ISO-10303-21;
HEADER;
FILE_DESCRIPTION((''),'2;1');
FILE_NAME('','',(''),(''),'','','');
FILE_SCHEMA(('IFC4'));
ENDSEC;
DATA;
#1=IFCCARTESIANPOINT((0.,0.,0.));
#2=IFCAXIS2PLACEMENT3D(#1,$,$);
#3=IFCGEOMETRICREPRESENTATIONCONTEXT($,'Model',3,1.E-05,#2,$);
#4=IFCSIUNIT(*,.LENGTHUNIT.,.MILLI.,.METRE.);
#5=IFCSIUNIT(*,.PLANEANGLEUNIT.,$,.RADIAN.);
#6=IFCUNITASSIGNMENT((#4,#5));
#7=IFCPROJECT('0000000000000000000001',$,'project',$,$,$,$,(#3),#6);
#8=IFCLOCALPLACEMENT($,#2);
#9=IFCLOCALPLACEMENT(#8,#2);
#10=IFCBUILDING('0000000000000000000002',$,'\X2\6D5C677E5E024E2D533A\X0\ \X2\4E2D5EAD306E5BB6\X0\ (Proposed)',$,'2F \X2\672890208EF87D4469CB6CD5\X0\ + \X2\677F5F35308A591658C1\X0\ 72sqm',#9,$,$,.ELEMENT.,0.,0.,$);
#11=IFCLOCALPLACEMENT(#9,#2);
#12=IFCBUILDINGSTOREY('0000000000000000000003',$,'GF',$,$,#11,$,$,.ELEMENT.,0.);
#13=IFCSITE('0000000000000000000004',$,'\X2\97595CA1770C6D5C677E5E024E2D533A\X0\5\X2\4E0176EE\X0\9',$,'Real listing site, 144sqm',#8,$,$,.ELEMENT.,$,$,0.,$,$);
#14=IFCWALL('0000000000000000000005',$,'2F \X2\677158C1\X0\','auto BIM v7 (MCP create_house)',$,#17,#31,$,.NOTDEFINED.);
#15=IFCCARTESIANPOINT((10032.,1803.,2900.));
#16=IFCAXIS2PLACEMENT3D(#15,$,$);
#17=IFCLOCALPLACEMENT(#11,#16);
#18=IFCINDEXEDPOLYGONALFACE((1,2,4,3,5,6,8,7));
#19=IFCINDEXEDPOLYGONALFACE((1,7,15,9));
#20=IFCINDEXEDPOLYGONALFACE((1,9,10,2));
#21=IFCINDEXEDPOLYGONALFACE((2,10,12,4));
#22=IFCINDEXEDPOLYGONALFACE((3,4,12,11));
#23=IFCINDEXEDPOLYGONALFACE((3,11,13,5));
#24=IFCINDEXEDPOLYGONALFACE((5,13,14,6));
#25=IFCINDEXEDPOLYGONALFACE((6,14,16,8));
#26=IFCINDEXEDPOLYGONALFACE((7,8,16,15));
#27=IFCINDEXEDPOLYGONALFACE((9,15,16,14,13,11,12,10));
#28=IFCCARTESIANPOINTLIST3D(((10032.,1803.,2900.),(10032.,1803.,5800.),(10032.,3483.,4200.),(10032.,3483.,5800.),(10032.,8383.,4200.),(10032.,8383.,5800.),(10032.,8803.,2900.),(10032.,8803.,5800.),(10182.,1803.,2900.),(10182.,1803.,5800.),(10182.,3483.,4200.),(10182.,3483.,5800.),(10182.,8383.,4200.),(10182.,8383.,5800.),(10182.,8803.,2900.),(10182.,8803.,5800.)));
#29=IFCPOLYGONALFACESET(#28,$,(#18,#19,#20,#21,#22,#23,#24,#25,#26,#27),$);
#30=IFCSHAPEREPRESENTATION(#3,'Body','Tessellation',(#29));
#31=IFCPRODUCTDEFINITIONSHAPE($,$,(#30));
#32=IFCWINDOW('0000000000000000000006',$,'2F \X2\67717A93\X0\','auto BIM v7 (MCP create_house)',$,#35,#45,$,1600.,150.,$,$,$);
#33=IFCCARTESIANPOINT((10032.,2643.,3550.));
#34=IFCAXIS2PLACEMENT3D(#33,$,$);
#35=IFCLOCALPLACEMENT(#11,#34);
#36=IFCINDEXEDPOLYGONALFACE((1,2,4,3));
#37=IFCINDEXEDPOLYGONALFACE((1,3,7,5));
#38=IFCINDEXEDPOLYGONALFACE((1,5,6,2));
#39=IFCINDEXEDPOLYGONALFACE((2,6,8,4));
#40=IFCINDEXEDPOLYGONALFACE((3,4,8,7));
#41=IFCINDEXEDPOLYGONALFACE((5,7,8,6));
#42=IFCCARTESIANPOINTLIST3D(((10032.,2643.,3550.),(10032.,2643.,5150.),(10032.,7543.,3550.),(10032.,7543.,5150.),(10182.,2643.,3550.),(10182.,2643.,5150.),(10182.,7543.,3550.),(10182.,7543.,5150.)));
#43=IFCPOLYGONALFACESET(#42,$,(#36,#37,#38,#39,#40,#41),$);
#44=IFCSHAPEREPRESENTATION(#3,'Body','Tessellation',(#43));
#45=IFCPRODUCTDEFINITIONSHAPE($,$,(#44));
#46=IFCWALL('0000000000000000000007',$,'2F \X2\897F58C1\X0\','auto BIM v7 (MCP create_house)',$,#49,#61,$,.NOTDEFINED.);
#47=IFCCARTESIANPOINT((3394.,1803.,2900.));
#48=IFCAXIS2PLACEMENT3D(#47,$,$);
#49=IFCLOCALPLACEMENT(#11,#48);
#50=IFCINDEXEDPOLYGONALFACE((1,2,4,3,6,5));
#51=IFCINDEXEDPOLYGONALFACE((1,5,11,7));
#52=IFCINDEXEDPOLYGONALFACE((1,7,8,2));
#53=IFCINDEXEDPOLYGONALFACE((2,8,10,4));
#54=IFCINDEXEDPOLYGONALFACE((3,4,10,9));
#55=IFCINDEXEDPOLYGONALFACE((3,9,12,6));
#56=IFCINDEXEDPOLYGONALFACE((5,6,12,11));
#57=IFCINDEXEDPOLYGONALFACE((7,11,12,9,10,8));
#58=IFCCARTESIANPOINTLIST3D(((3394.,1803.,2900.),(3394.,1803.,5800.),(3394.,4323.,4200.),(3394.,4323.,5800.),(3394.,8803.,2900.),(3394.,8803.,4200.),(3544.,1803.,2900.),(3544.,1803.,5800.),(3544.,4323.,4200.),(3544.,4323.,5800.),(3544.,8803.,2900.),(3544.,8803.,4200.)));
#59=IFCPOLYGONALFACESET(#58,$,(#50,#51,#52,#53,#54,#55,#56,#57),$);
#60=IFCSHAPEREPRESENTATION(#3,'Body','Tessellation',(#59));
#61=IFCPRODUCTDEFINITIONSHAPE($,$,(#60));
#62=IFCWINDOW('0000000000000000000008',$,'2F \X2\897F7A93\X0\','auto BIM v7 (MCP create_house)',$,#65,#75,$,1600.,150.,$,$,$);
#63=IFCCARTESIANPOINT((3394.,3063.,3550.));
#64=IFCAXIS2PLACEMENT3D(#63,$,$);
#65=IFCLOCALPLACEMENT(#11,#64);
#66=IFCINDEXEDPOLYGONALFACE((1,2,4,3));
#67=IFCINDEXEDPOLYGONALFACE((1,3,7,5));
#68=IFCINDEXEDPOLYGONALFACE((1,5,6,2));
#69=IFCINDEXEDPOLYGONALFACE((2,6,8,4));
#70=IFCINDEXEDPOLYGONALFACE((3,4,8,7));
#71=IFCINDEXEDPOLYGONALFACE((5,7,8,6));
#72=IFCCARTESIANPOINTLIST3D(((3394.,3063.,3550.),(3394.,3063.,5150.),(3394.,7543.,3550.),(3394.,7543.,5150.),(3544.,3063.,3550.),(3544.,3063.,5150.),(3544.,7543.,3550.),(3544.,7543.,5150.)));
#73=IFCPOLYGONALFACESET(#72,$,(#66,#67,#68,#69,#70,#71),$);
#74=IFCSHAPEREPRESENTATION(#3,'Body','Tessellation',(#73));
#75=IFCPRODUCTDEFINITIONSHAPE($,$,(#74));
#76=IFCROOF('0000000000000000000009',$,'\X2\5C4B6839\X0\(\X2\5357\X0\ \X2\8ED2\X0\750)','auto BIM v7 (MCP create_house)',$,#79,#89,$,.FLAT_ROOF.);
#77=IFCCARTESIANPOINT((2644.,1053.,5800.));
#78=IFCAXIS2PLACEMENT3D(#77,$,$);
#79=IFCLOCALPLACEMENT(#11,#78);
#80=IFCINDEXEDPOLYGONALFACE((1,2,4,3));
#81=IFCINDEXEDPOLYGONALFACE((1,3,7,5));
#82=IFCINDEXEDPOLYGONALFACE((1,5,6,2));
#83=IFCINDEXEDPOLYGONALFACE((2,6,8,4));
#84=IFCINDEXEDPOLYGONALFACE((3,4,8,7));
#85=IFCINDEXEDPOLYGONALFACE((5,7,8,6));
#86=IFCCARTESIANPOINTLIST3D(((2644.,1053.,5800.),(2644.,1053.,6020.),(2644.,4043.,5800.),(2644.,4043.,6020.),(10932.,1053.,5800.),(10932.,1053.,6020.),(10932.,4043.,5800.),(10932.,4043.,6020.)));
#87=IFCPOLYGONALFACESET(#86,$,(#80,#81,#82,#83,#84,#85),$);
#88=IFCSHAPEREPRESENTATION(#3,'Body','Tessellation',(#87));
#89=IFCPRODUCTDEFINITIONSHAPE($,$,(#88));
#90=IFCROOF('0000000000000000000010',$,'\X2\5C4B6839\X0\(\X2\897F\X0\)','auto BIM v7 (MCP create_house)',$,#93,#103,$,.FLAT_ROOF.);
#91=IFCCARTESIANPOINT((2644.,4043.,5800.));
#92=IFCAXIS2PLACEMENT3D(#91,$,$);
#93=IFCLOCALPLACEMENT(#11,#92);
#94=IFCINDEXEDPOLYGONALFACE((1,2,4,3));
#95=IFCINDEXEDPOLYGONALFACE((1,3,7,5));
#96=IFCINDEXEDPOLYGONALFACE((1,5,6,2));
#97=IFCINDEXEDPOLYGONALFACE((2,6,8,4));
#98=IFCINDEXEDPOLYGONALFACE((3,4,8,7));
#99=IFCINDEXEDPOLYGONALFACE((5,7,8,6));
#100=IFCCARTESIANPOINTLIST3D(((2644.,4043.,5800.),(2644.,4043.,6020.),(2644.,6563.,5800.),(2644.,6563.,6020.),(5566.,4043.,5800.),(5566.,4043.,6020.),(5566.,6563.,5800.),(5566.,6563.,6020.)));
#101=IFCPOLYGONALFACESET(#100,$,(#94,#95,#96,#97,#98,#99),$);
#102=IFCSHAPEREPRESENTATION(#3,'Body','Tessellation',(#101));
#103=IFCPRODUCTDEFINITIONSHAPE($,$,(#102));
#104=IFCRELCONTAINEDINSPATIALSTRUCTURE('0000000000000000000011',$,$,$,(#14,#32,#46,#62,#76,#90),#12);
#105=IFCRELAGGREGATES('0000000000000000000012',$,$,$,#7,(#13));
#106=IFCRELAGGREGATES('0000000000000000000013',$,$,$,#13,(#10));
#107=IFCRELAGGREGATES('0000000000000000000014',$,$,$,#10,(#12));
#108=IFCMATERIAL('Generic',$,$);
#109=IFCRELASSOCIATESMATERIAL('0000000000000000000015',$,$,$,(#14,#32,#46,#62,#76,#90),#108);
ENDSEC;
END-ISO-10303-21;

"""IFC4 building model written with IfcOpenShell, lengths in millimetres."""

from ifc_helpers import new_model, si_unit, frame, frame_2d, origin, place, context, project, spatial, rectangle, extrude, material, element, fill, save


model = new_model("IFC4")

# Units and contexts
model_context = context("Model", 3, precision=1e-05, world=origin())
ifc_project = project(units=[si_unit("LENGTHUNIT", "METRE", prefix="MILLI"), si_unit("PLANEANGLEUNIT", "RADIAN")], contexts=[model_context])

# Site, building, storey
site_placement = place(None, origin())
site = spatial("IfcSite", under=ifc_project, at=site_placement, Name="静岡県浜松市中区5丁目9", ObjectType="Real listing site, 144sqm", CompositionType="ELEMENT", RefElevation=0.0)
building_placement = place(site_placement, origin())
building = spatial("IfcBuilding", under=site, at=building_placement, Name="浜松市中区 中庭の家 (Proposed)", ObjectType="2F 木造軸組構法 + 板張り外壁 72sqm", CompositionType="ELEMENT", ElevationOfRefHeight=0.0, ElevationOfTerrain=0.0)
storey_placement = place(building_placement, origin())
storey = spatial("IfcBuildingStorey", under=building, at=storey_placement, Name="GF", CompositionType="ELEMENT", Elevation=0.0)

# Shared definitions
ifc_material = material(Name="Generic")

# Walls, openings, windows
wall_1_placement = place(storey_placement, frame((10032.0, 1803.0, 2900.0)))
wall_1 = element("IfcWall", 1, at=wall_1_placement, inside=storey, material=ifc_material, Name="2F 東壁", Description="auto BIM v7 (MCP create_house)", PredefinedType="NOTDEFINED", context=model_context, shape_type="SweptSolid", body=[
    extrude(rectangle(XDim=150.0, YDim=7000.0, at=frame_2d((75.0, 3500.0))), frame((10032.0, 1803.0, 2900.0)), (0.0, 0.0, 1.0), 2900.0),
])
opening_1_placement = place(storey_placement, frame((10032.0, 2643.0, 3550.0)))
opening_1 = element("IfcOpeningElement", 2, at=opening_1_placement, cuts=wall_1, PredefinedType="NOTDEFINED", context=model_context, shape_type="SweptSolid", body=[
    extrude(rectangle(XDim=150.0, YDim=4900.0, at=frame_2d((75.0, 2450.0))), frame((10032.0, 2643.0, 3550.0)), (0.0, 0.0, 1.0), 1600.0),
])
window_1_placement = place(storey_placement, frame((10032.0, 2643.0, 3550.0)))
window_1 = element("IfcWindow", 3, at=window_1_placement, inside=storey, material=ifc_material, Name="2F 東窓", Description="auto BIM v7 (MCP create_house)", OverallHeight=1600.0, OverallWidth=150.0, context=model_context, shape_type="SweptSolid", body=[
    extrude(rectangle(XDim=150.0, YDim=4900.0, at=frame_2d((75.0, 2450.0))), frame((10032.0, 2643.0, 3550.0)), (0.0, 0.0, 1.0), 1600.0),
])
fill(opening_1, window_1)
wall_2_placement = place(storey_placement, frame((3394.0, 1803.0, 2900.0)))
wall_2 = element("IfcWall", 4, at=wall_2_placement, inside=storey, material=ifc_material, Name="2F 西壁", Description="auto BIM v7 (MCP create_house)", PredefinedType="NOTDEFINED", context=model_context, shape_type="SweptSolid", body=[
    extrude(rectangle(XDim=150.0, YDim=7000.0, at=frame_2d((75.0, 3500.0))), frame((3394.0, 1803.0, 2900.0)), (0.0, 0.0, 1.0), 2900.0),
])
opening_2_placement = place(storey_placement, frame((3394.0, 3063.0, 3550.0)))
opening_2 = element("IfcOpeningElement", 5, at=opening_2_placement, cuts=wall_2, PredefinedType="NOTDEFINED", context=model_context, shape_type="SweptSolid", body=[
    extrude(rectangle(XDim=150.0, YDim=4480.0, at=frame_2d((75.0, 2240.0))), frame((3394.0, 3063.0, 3550.0)), (0.0, 0.0, 1.0), 1600.0),
])
window_2_placement = place(storey_placement, frame((3394.0, 3063.0, 3550.0)))
window_2 = element("IfcWindow", 6, at=window_2_placement, inside=storey, material=ifc_material, Name="2F 西窓", Description="auto BIM v7 (MCP create_house)", OverallHeight=1600.0, OverallWidth=150.0, context=model_context, shape_type="SweptSolid", body=[
    extrude(rectangle(XDim=150.0, YDim=4480.0, at=frame_2d((75.0, 2240.0))), frame((3394.0, 3063.0, 3550.0)), (0.0, 0.0, 1.0), 1600.0),
])
fill(opening_2, window_2)

# Roofs
roof_1_placement = place(storey_placement, frame((2644.0, 1053.0, 5800.0)))
element("IfcRoof", 7, at=roof_1_placement, inside=storey, material=ifc_material, Name="屋根(南 軒750)", Description="auto BIM v7 (MCP create_house)", PredefinedType="FLAT_ROOF", context=model_context, shape_type="SweptSolid", body=[
    extrude(rectangle(XDim=8288.0, YDim=2990.0, at=frame_2d((4144.0, 1495.0))), frame((2644.0, 1053.0, 5800.0)), (0.0, 0.0, 1.0), 220.0),
])
roof_2_placement = place(storey_placement, frame((2644.0, 4043.0, 5800.0)))
element("IfcRoof", 8, at=roof_2_placement, inside=storey, material=ifc_material, Name="屋根(西)", Description="auto BIM v7 (MCP create_house)", PredefinedType="FLAT_ROOF", context=model_context, shape_type="SweptSolid", body=[
    extrude(rectangle(XDim=2922.0, YDim=2520.0, at=frame_2d((1461.0, 1260.0))), frame((2644.0, 4043.0, 5800.0)), (0.0, 0.0, 1.0), 220.0),
])

save(model, "model.ifc")
